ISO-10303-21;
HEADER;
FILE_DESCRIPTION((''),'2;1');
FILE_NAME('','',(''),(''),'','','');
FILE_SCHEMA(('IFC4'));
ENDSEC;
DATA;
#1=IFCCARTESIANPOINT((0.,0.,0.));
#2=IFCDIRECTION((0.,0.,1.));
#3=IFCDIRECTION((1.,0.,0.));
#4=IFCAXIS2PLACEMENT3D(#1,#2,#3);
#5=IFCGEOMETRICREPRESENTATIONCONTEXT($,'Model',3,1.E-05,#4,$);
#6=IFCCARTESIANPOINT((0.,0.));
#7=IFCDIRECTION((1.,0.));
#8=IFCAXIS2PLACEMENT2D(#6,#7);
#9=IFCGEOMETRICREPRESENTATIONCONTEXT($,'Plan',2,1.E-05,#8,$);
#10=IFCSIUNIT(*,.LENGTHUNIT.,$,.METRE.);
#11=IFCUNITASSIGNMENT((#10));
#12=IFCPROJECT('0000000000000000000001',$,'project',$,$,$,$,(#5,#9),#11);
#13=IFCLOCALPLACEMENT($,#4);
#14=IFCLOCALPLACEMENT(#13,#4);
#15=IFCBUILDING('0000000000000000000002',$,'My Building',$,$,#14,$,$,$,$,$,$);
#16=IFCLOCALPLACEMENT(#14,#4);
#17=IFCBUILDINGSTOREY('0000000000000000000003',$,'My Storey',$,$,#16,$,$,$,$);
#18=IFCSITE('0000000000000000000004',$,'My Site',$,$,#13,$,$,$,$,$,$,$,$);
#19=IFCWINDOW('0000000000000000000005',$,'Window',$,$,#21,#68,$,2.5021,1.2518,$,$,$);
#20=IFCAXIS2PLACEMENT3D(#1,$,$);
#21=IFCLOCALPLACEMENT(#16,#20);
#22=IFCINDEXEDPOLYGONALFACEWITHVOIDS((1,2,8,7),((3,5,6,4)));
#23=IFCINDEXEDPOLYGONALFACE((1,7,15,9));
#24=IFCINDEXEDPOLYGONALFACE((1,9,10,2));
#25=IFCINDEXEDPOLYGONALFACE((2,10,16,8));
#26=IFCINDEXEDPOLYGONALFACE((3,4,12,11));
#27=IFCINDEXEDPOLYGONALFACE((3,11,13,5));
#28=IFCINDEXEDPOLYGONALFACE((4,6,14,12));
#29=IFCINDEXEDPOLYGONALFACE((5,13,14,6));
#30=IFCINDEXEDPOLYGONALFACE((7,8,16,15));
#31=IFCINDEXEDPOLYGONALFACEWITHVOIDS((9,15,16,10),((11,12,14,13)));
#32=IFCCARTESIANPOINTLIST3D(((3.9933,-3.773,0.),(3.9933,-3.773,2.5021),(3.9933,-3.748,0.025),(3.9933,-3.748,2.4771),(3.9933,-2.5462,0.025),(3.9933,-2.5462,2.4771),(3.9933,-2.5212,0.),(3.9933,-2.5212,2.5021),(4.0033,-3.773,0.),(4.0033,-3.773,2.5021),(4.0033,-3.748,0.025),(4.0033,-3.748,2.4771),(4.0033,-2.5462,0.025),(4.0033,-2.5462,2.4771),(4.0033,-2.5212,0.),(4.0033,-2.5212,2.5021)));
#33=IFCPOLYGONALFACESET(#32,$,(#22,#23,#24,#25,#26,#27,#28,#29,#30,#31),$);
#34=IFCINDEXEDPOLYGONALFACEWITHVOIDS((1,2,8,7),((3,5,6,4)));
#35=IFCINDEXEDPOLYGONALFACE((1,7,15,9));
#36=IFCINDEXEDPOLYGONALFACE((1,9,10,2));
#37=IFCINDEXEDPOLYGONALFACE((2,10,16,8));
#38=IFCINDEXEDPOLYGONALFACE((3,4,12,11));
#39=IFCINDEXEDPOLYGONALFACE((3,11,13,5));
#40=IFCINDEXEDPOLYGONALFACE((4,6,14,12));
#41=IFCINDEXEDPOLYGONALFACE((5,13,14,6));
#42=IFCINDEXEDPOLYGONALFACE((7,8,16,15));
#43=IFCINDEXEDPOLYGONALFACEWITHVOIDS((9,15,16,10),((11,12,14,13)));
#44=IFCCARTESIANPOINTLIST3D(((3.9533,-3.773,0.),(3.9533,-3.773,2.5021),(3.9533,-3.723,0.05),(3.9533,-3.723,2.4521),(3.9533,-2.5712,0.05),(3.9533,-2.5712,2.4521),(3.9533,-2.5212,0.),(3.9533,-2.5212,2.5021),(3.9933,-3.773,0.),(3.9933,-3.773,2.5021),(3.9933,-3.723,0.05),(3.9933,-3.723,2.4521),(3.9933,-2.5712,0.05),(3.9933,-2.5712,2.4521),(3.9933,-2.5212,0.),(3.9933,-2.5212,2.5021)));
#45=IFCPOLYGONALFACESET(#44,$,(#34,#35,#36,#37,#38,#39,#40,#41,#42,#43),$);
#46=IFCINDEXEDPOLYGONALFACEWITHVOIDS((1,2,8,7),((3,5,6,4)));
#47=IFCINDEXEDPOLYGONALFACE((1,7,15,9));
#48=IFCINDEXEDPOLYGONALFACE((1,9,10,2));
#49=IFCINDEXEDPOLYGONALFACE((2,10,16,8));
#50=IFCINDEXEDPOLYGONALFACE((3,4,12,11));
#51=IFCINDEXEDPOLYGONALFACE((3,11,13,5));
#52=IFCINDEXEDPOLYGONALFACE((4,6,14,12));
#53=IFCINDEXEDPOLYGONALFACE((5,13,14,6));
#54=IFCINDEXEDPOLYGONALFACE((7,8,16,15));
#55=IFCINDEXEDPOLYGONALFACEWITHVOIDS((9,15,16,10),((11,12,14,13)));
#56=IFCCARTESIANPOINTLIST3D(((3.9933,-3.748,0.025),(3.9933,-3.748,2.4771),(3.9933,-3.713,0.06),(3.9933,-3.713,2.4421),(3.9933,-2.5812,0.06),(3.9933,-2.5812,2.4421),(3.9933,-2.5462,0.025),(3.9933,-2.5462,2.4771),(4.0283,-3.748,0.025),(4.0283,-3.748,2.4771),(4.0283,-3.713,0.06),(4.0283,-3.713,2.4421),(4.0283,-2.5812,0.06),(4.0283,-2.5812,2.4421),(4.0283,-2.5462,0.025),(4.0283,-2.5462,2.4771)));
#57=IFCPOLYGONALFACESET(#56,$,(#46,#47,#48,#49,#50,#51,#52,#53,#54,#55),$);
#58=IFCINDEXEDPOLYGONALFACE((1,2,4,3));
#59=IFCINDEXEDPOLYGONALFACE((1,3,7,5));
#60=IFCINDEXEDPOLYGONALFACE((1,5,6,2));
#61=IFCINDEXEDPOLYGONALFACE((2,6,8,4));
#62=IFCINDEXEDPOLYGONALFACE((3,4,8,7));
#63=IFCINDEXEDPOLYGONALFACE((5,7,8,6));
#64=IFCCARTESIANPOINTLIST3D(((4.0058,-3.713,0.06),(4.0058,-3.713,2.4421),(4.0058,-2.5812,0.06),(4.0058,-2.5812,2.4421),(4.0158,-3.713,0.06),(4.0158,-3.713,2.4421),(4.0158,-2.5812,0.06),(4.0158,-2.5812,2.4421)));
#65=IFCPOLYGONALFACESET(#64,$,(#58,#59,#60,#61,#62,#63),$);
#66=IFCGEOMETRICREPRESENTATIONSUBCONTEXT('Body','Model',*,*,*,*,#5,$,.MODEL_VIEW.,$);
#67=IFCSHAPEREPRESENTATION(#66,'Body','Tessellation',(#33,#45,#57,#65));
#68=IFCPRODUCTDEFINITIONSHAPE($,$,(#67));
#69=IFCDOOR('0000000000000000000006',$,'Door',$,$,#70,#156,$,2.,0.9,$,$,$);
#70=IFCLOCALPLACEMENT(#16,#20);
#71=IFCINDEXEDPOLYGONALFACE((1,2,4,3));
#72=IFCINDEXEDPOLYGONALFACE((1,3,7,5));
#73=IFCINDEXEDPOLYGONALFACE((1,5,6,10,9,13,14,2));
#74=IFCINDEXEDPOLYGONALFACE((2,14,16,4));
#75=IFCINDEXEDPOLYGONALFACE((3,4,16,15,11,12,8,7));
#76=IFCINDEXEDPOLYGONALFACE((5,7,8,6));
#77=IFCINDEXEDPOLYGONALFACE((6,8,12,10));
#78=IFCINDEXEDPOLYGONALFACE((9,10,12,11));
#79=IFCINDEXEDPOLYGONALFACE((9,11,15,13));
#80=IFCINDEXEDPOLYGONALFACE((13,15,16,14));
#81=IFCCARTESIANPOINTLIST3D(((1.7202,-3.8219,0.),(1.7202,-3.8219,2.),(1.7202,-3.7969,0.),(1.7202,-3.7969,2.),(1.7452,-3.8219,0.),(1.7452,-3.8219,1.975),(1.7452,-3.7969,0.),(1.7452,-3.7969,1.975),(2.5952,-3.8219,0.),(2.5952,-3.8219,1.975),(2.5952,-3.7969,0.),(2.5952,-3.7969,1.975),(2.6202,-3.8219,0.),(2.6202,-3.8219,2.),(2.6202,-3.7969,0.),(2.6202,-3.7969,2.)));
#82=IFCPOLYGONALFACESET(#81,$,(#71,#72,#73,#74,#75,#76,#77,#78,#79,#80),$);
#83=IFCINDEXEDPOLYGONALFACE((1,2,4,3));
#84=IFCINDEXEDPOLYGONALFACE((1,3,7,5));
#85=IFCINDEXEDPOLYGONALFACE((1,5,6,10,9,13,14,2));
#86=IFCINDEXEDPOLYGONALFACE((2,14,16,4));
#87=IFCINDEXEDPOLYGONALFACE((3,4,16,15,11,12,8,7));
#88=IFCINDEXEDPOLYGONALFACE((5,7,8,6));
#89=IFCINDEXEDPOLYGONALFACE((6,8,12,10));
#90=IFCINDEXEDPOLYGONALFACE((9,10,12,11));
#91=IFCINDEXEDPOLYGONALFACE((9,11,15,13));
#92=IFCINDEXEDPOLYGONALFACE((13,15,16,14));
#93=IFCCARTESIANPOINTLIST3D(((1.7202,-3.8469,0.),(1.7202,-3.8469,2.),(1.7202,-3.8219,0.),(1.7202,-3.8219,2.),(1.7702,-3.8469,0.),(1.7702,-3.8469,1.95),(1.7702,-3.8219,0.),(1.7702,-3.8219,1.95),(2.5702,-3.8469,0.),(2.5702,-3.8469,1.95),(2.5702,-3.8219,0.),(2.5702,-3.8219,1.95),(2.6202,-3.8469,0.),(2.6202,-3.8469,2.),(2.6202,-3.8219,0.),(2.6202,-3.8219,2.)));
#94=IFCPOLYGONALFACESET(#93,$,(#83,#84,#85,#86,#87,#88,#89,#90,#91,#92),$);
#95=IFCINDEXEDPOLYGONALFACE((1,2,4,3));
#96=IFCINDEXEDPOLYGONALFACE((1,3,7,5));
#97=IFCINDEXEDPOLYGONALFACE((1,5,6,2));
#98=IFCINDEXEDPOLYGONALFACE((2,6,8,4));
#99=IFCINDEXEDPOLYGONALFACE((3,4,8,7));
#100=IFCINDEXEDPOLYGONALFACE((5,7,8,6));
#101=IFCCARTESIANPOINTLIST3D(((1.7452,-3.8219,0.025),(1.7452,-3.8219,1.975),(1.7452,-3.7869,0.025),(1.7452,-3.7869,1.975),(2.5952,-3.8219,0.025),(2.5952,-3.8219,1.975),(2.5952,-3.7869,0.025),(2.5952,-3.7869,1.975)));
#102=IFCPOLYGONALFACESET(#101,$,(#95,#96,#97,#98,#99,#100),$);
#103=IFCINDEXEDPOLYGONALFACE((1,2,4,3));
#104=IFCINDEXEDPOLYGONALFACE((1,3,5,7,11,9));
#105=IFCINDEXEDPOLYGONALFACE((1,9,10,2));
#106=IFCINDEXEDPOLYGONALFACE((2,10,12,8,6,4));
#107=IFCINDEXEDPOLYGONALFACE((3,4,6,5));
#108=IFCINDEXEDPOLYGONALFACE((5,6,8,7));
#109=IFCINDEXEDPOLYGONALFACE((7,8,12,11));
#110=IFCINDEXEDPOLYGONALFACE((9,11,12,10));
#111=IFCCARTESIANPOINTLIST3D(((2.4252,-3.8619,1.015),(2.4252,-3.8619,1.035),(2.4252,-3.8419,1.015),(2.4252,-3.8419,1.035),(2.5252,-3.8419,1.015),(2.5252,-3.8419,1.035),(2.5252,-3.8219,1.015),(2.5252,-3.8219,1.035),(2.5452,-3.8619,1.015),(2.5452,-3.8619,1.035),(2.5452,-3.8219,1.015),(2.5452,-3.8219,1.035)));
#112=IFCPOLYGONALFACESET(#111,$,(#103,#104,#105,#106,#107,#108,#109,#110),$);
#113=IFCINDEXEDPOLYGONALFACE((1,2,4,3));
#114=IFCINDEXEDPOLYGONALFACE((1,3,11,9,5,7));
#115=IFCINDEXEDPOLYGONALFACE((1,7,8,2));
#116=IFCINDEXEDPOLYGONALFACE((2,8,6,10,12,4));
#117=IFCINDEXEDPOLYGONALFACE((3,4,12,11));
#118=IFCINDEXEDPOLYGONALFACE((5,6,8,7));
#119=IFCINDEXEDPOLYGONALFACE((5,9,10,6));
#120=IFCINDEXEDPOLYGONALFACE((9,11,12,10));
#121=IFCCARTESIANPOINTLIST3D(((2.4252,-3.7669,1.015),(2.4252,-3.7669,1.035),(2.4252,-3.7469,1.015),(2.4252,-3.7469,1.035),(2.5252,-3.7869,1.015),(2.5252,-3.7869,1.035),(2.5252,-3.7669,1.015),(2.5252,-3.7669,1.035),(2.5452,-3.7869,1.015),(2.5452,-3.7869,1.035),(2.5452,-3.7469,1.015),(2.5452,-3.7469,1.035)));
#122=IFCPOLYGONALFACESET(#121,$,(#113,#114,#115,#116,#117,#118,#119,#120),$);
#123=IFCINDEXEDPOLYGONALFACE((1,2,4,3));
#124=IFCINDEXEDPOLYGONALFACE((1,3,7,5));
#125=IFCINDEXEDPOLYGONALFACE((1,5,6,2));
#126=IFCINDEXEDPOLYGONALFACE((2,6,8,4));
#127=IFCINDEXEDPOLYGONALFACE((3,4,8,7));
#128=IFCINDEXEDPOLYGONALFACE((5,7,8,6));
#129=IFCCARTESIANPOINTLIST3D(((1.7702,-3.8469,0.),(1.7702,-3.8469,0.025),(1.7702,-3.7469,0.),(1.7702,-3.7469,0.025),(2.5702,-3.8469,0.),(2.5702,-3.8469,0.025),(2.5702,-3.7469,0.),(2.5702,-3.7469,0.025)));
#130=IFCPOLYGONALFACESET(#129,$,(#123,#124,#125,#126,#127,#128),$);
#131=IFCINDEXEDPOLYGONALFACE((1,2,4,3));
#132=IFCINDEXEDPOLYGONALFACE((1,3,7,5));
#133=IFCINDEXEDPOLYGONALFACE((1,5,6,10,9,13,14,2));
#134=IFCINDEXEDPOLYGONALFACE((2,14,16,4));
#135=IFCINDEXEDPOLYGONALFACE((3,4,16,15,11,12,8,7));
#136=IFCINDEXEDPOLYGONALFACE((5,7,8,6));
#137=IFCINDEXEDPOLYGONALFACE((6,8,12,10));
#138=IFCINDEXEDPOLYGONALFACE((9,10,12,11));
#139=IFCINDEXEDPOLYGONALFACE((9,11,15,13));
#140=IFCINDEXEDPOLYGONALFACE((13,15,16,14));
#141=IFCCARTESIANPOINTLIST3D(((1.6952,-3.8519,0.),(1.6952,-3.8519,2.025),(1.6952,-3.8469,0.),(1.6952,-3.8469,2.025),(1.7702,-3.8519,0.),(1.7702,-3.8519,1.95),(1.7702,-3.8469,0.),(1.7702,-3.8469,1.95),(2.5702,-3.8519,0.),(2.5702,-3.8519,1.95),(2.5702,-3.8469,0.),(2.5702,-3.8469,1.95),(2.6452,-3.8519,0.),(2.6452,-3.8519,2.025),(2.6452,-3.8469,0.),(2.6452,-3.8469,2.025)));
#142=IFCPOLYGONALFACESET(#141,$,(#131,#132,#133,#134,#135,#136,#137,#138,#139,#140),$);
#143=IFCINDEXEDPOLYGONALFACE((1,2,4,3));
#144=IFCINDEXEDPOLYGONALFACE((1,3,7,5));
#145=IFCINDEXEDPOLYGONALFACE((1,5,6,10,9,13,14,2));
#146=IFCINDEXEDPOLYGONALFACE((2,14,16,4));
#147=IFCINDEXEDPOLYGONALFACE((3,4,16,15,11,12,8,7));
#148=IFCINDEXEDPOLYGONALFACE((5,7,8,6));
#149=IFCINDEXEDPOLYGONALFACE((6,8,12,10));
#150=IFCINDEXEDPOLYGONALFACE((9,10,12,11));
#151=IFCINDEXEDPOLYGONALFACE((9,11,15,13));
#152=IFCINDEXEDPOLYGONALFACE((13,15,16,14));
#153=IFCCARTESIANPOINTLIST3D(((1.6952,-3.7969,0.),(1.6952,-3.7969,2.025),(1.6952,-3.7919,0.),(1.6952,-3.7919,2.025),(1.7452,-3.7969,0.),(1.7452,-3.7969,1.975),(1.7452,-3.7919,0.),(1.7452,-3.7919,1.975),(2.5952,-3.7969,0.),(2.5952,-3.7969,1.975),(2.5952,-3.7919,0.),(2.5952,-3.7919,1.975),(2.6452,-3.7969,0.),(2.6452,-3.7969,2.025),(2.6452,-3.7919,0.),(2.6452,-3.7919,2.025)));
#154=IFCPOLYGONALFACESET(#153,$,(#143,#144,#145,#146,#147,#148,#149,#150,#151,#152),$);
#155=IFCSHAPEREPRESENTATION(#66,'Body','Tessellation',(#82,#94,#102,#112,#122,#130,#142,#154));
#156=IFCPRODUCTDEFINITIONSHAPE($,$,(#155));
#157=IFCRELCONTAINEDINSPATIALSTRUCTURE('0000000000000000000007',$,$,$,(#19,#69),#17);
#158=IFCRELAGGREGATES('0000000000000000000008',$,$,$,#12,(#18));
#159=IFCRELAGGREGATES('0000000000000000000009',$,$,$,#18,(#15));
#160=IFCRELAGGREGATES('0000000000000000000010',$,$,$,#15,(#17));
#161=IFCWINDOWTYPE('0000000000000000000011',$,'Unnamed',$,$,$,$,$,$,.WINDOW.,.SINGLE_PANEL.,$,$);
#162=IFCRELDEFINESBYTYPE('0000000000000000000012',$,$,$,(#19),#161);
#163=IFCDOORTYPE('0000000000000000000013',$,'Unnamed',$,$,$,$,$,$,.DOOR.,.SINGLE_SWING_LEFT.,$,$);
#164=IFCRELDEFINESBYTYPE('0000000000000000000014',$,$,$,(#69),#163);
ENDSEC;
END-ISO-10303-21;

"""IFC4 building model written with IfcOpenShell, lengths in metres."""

from ifc_helpers import new_model, entity, si_unit, frame, origin_with_axes, origin_2d_with_axis, place, context, subcontext, project, spatial, line, indexed_curve, outline, extrude, shape, source, transform, mapped, type_object, type_shapes, element, save


model = new_model("IFC4")

# Units and contexts
model_context = context("Model", 3, precision=1e-05, world=origin_with_axes())
plan_context = context("Plan", 2, precision=1e-05, world=origin_2d_with_axis())
body_context_1 = subcontext(model_context, "Body", "Model", "MODEL_VIEW")
body_context_2 = subcontext(plan_context, "Body", "Plan", "PLAN_VIEW")
ifc_project = project(units=[si_unit("LENGTHUNIT", "METRE")], contexts=[model_context, plan_context])

# Site, building, storey
site_placement = place(None, origin_with_axes())
site = spatial("IfcSite", under=ifc_project, at=site_placement, Name="My Site")
building_placement = place(site_placement, origin_with_axes())
building = spatial("IfcBuilding", under=site, at=building_placement, Name="My Building")
storey_placement = place(building_placement, origin_with_axes())
storey = spatial("IfcBuildingStorey", under=building, at=storey_placement, Name="My Storey")

# Window
window_type = type_object("IfcWindowType", Name="Unnamed", PartitioningType="SINGLE_PANEL", PredefinedType="WINDOW")
shared_shape_1 = source(origin_with_axes(), body_context_1, "Body", "SweptSolid", [
    extrude(outline(indexed_curve([(0.0, 0.0), (1.2518, 0.0), (1.2518, 2.5021), (0.0, 2.5021)], segments=[line(1, 2, 3, 4, 1)]), holes=[indexed_curve([(0.025, 0.025), (1.2268, 0.025), (1.2268, 2.4771), (0.025, 2.4771)], segments=[line(1, 2, 3, 4, 1)])]), frame((0.0, 0.09, 0.0), z_axis=(0.0, -1.0, 0.0), x_axis=(1.0, 0.0, 0.0)), (0.0, 0.0, -1.0), 0.01),
    extrude(outline(indexed_curve([(0.0, 0.0), (1.2518, 0.0), (1.2518, 2.5021), (0.0, 2.5021)], segments=[line(1, 2, 3, 4, 1)]), holes=[indexed_curve([(0.05, 0.05), (1.2018, 0.05), (1.2018, 2.4521), (0.05, 2.4521)], segments=[line(1, 2, 3, 4, 1)])]), frame((0.0, 0.05, 0.0), z_axis=(0.0, -1.0, 0.0), x_axis=(1.0, 0.0, 0.0)), (0.0, 0.0, -1.0), 0.04),
    extrude(outline(indexed_curve([(0.0, 0.0), (1.2018, 0.0), (1.2018, 2.4521), (0.0, 2.4521)], segments=[line(1, 2, 3, 4, 1)]), holes=[indexed_curve([(0.035, 0.035), (1.1668, 0.035), (1.1668, 2.4171), (0.035, 2.4171)], segments=[line(1, 2, 3, 4, 1)])]), frame((0.025, 0.09, 0.025), z_axis=(0.0, -1.0, 0.0), x_axis=(1.0, 0.0, 0.0)), (0.0, 0.0, -1.0), 0.035),
    extrude(outline(indexed_curve([(0.035, 0.035), (1.1668, 0.035), (1.1668, 2.4171), (0.035, 2.4171)], segments=[line(1, 2, 3, 4, 1)])), frame((0.025, 0.1025, 0.025), z_axis=(0.0, -1.0, 0.0), x_axis=(1.0, 0.0, 0.0)), (0.0, 0.0, -1.0), 0.01),
])
shared_shape_2 = source(origin_with_axes(), body_context_2, "Body", "Curve2D", [
    entity("IfcIndexedPolyCurve", entity("IfcCartesianPointList2D", [[0.05, 0.05], [1.2018, 0.05]])),
    entity("IfcIndexedPolyCurve", entity("IfcCartesianPointList2D", [[0.0, 0.1], [0.025, 0.1], [0.025, 0.09], [0.05, 0.09], [0.05, 0.05], [0.0, 0.05]]), [entity("IfcLineIndex", [1, 2, 3, 4, 5, 6, 1])]),
    entity("IfcIndexedPolyCurve", entity("IfcCartesianPointList2D", [[1.2518, 0.1], [1.2268, 0.1], [1.2268, 0.09], [1.2018, 0.09], [1.2018, 0.05], [1.2518, 0.05]]), [entity("IfcLineIndex", [1, 2, 3, 4, 5, 6, 1])]),
    entity("IfcIndexedPolyCurve", entity("IfcCartesianPointList2D", [[0.025, 0.09], [0.06, 0.09], [0.06, 0.125], [0.025, 0.125]]), [entity("IfcLineIndex", [1, 2, 3, 4, 1])]),
    entity("IfcIndexedPolyCurve", entity("IfcCartesianPointList2D", [[1.2268, 0.09], [1.1918, 0.09], [1.1918, 0.125], [1.2268, 0.125]]), [entity("IfcLineIndex", [1, 2, 3, 4, 1])]),
    entity("IfcIndexedPolyCurve", entity("IfcCartesianPointList2D", [[0.06, 0.09], [1.1918, 0.09]])),
    entity("IfcIndexedPolyCurve", entity("IfcCartesianPointList2D", [[0.06, 0.125], [1.1918, 0.125]])),
    entity("IfcIndexedPolyCurve", entity("IfcCartesianPointList2D", [[0.06, 0.1075], [1.1918, 0.1075]])),
])
type_shapes(window_type, [shared_shape_1, shared_shape_2])
for number, where, z_axis, x_axis, name in (
    (1, (3.9033, -2.5212, 0.0), (0.0, 0.0, 1.0), (0.0, -1.0, 0.0), "Window"),
):
    element("IfcWindow", number, at=place(storey_placement, frame(where, z_axis=z_axis, x_axis=x_axis)), inside=storey, type_object=window_type, Name=name, OverallHeight=2.5021, OverallWidth=1.2518, shapes=[
        shape(body_context_1, "Body", "MappedRepresentation", [mapped(shared_shape_1, transform((0.0, 0.0, 0.0), x_axis=(1.0, 0.0, 0.0), y_axis=(0.0, 1.0, 0.0), z_axis=(0.0, 0.0, 1.0), scale=1.0))]),
        shape(body_context_2, "Body", "MappedRepresentation", [mapped(shared_shape_2, transform((0.0, 0.0, 0.0), x_axis=(1.0, 0.0, 0.0), y_axis=(0.0, 1.0, 0.0), z_axis=(0.0, 0.0, 1.0), scale=1.0))]),
    ])

# Door
door_type_1 = type_object("IfcDoorType", Name="Unnamed", OperationType="SINGLE_SWING_LEFT", PredefinedType="DOOR")
shared_shape_3 = source(origin_with_axes(), body_context_1, "Body", "SweptSolid", [
    extrude(outline(indexed_curve([(0.0, 0.0), (0.0, 2.0), (0.9, 2.0), (0.9, 0.0), (0.875, 0.0), (0.875, 1.975), (0.025, 1.975), (0.025, 0.0)], segments=[line(1, 2, 3, 4, 5, 6, 7, 8, 1)])), frame((0.0, 0.025, 0.0), z_axis=(0.0, -1.0, 0.0), x_axis=(1.0, 0.0, 0.0)), (0.0, 0.0, -1.0), 0.025),
    extrude(outline(indexed_curve([(0.0, 0.0), (0.0, 2.0), (0.9, 2.0), (0.9, 0.0), (0.85, 0.0), (0.85, 1.95), (0.05, 1.95), (0.05, 0.0)], segments=[line(1, 2, 3, 4, 5, 6, 7, 8, 1)])), frame((0.0, 0.0, 0.0), z_axis=(0.0, -1.0, 0.0), x_axis=(1.0, 0.0, 0.0)), (0.0, 0.0, -1.0), 0.025),
    extrude(outline(indexed_curve([(0.0, 0.0), (0.85, 0.0), (0.85, 0.035), (0.0, 0.035)], segments=[line(1, 2, 3, 4, 1)])), frame((0.025, 0.025, 0.025), z_axis=(0.0, 0.0, 1.0), x_axis=(1.0, 0.0, 0.0)), (0.0, 0.0, 1.0), 1.95),
    extrude(outline(indexed_curve([(0.0, 0.0), (0.0, -0.04), (-0.12, -0.04), (-0.12, -0.02), (-0.02, -0.02), (-0.02, 0.0)], segments=[line(1, 2, 3, 4, 5, 6, 1)])), frame((0.825, 0.025, 1.015), z_axis=(0.0, 0.0, 1.0), x_axis=(1.0, 0.0, 0.0)), (0.0, 0.0, 1.0), 0.02),
    extrude(outline(indexed_curve([(0.0, 0.0), (0.0, 0.04), (-0.12, 0.04), (-0.12, 0.02), (-0.02, 0.02), (-0.02, 0.0)], segments=[line(1, 2, 3, 4, 5, 6, 1)])), frame((0.825, 0.06, 1.015), z_axis=(0.0, 0.0, 1.0), x_axis=(1.0, 0.0, 0.0)), (0.0, 0.0, 1.0), 0.02),
    extrude(outline(indexed_curve([(0.0, 0.0), (0.8, 0.0), (0.8, 0.1), (0.0, 0.1)], segments=[line(1, 2, 3, 4, 1)])), frame((0.05, 0.0, 0.0), z_axis=(0.0, 0.0, 1.0), x_axis=(1.0, 0.0, 0.0)), (0.0, 0.0, 1.0), 0.025),
    extrude(outline(indexed_curve([(0.0, 0.0), (0.0, 2.025), (0.95, 2.025), (0.95, 0.0), (0.875, 0.0), (0.875, 1.95), (0.075, 1.95), (0.075, 0.0)], segments=[line(1, 2, 3, 4, 5, 6, 7, 8, 1)])), frame((-0.025, -0.005, 0.0), z_axis=(0.0, -1.0, 0.0), x_axis=(1.0, 0.0, 0.0)), (0.0, 0.0, -1.0), 0.005),
    extrude(outline(indexed_curve([(0.0, 0.0), (0.0, 2.025), (0.95, 2.025), (0.95, 0.0), (0.9, 0.0), (0.9, 1.975), (0.05, 1.975), (0.05, 0.0)], segments=[line(1, 2, 3, 4, 5, 6, 7, 8, 1)])), frame((-0.025, 0.05, 0.0), z_axis=(0.0, -1.0, 0.0), x_axis=(1.0, 0.0, 0.0)), (0.0, 0.0, -1.0), 0.005),
])
shared_shape_4 = source(origin_with_axes(), body_context_2, "Body", "Curve2D", [
    entity("IfcIndexedPolyCurve", entity("IfcCartesianPointList2D", [[0.0, 0.0], [0.0, 0.05], [0.025, 0.05], [0.025, 0.025], [0.05, 0.025], [0.05, 0.0]]), [entity("IfcLineIndex", [1, 2, 3, 4, 5, 6, 1])]),
    entity("IfcIndexedPolyCurve", entity("IfcCartesianPointList2D", [[0.9, 0.0], [0.9, 0.05], [0.875, 0.05], [0.875, 0.025], [0.85, 0.025], [0.85, 0.0]]), [entity("IfcLineIndex", [1, 2, 3, 4, 5, 6, 1])]),
    entity("IfcTrimmedCurve", entity("IfcEllipse", entity("IfcAxis2Placement2D", entity("IfcCartesianPoint", [0.06, 0.05]), entity("IfcDirection", [1.0, 0.0])), 0.815, 0.85), [entity("IfcCartesianPoint", [0.875, 0.05])], [entity("IfcCartesianPoint", [0.06, 0.9])], True, "CARTESIAN"),
    entity("IfcIndexedPolyCurve", entity("IfcCartesianPointList2D", [[0.025, 0.05], [0.06, 0.05], [0.06, 0.9], [0.025, 0.9]]), [entity("IfcLineIndex", [1, 2, 3, 4, 1])]),
])
type_shapes(door_type_1, [shared_shape_3, shared_shape_4])
door_1_placement = place(storey_placement, frame((1.7202, -3.8469, 0.0), z_axis=(0.0, 0.0, 1.0), x_axis=(1.0, 0.0, 0.0)))
element("IfcDoor", 2, at=door_1_placement, inside=storey, type_object=door_type_1, Name="Door", OverallHeight=2.0, OverallWidth=0.9, shapes=[
    shape(body_context_1, "Body", "MappedRepresentation", [mapped(shared_shape_3, transform((0.0, 0.0, 0.0), x_axis=(1.0, 0.0, 0.0), y_axis=(0.0, 1.0, 0.0), z_axis=(0.0, 0.0, 1.0), scale=1.0))]),
    shape(body_context_2, "Body", "MappedRepresentation", [mapped(shared_shape_4, transform((0.0, 0.0, 0.0), x_axis=(1.0, 0.0, 0.0), y_axis=(0.0, 1.0, 0.0), z_axis=(0.0, 0.0, 1.0), scale=1.0))]),
])

save(model, "model.ifc")
